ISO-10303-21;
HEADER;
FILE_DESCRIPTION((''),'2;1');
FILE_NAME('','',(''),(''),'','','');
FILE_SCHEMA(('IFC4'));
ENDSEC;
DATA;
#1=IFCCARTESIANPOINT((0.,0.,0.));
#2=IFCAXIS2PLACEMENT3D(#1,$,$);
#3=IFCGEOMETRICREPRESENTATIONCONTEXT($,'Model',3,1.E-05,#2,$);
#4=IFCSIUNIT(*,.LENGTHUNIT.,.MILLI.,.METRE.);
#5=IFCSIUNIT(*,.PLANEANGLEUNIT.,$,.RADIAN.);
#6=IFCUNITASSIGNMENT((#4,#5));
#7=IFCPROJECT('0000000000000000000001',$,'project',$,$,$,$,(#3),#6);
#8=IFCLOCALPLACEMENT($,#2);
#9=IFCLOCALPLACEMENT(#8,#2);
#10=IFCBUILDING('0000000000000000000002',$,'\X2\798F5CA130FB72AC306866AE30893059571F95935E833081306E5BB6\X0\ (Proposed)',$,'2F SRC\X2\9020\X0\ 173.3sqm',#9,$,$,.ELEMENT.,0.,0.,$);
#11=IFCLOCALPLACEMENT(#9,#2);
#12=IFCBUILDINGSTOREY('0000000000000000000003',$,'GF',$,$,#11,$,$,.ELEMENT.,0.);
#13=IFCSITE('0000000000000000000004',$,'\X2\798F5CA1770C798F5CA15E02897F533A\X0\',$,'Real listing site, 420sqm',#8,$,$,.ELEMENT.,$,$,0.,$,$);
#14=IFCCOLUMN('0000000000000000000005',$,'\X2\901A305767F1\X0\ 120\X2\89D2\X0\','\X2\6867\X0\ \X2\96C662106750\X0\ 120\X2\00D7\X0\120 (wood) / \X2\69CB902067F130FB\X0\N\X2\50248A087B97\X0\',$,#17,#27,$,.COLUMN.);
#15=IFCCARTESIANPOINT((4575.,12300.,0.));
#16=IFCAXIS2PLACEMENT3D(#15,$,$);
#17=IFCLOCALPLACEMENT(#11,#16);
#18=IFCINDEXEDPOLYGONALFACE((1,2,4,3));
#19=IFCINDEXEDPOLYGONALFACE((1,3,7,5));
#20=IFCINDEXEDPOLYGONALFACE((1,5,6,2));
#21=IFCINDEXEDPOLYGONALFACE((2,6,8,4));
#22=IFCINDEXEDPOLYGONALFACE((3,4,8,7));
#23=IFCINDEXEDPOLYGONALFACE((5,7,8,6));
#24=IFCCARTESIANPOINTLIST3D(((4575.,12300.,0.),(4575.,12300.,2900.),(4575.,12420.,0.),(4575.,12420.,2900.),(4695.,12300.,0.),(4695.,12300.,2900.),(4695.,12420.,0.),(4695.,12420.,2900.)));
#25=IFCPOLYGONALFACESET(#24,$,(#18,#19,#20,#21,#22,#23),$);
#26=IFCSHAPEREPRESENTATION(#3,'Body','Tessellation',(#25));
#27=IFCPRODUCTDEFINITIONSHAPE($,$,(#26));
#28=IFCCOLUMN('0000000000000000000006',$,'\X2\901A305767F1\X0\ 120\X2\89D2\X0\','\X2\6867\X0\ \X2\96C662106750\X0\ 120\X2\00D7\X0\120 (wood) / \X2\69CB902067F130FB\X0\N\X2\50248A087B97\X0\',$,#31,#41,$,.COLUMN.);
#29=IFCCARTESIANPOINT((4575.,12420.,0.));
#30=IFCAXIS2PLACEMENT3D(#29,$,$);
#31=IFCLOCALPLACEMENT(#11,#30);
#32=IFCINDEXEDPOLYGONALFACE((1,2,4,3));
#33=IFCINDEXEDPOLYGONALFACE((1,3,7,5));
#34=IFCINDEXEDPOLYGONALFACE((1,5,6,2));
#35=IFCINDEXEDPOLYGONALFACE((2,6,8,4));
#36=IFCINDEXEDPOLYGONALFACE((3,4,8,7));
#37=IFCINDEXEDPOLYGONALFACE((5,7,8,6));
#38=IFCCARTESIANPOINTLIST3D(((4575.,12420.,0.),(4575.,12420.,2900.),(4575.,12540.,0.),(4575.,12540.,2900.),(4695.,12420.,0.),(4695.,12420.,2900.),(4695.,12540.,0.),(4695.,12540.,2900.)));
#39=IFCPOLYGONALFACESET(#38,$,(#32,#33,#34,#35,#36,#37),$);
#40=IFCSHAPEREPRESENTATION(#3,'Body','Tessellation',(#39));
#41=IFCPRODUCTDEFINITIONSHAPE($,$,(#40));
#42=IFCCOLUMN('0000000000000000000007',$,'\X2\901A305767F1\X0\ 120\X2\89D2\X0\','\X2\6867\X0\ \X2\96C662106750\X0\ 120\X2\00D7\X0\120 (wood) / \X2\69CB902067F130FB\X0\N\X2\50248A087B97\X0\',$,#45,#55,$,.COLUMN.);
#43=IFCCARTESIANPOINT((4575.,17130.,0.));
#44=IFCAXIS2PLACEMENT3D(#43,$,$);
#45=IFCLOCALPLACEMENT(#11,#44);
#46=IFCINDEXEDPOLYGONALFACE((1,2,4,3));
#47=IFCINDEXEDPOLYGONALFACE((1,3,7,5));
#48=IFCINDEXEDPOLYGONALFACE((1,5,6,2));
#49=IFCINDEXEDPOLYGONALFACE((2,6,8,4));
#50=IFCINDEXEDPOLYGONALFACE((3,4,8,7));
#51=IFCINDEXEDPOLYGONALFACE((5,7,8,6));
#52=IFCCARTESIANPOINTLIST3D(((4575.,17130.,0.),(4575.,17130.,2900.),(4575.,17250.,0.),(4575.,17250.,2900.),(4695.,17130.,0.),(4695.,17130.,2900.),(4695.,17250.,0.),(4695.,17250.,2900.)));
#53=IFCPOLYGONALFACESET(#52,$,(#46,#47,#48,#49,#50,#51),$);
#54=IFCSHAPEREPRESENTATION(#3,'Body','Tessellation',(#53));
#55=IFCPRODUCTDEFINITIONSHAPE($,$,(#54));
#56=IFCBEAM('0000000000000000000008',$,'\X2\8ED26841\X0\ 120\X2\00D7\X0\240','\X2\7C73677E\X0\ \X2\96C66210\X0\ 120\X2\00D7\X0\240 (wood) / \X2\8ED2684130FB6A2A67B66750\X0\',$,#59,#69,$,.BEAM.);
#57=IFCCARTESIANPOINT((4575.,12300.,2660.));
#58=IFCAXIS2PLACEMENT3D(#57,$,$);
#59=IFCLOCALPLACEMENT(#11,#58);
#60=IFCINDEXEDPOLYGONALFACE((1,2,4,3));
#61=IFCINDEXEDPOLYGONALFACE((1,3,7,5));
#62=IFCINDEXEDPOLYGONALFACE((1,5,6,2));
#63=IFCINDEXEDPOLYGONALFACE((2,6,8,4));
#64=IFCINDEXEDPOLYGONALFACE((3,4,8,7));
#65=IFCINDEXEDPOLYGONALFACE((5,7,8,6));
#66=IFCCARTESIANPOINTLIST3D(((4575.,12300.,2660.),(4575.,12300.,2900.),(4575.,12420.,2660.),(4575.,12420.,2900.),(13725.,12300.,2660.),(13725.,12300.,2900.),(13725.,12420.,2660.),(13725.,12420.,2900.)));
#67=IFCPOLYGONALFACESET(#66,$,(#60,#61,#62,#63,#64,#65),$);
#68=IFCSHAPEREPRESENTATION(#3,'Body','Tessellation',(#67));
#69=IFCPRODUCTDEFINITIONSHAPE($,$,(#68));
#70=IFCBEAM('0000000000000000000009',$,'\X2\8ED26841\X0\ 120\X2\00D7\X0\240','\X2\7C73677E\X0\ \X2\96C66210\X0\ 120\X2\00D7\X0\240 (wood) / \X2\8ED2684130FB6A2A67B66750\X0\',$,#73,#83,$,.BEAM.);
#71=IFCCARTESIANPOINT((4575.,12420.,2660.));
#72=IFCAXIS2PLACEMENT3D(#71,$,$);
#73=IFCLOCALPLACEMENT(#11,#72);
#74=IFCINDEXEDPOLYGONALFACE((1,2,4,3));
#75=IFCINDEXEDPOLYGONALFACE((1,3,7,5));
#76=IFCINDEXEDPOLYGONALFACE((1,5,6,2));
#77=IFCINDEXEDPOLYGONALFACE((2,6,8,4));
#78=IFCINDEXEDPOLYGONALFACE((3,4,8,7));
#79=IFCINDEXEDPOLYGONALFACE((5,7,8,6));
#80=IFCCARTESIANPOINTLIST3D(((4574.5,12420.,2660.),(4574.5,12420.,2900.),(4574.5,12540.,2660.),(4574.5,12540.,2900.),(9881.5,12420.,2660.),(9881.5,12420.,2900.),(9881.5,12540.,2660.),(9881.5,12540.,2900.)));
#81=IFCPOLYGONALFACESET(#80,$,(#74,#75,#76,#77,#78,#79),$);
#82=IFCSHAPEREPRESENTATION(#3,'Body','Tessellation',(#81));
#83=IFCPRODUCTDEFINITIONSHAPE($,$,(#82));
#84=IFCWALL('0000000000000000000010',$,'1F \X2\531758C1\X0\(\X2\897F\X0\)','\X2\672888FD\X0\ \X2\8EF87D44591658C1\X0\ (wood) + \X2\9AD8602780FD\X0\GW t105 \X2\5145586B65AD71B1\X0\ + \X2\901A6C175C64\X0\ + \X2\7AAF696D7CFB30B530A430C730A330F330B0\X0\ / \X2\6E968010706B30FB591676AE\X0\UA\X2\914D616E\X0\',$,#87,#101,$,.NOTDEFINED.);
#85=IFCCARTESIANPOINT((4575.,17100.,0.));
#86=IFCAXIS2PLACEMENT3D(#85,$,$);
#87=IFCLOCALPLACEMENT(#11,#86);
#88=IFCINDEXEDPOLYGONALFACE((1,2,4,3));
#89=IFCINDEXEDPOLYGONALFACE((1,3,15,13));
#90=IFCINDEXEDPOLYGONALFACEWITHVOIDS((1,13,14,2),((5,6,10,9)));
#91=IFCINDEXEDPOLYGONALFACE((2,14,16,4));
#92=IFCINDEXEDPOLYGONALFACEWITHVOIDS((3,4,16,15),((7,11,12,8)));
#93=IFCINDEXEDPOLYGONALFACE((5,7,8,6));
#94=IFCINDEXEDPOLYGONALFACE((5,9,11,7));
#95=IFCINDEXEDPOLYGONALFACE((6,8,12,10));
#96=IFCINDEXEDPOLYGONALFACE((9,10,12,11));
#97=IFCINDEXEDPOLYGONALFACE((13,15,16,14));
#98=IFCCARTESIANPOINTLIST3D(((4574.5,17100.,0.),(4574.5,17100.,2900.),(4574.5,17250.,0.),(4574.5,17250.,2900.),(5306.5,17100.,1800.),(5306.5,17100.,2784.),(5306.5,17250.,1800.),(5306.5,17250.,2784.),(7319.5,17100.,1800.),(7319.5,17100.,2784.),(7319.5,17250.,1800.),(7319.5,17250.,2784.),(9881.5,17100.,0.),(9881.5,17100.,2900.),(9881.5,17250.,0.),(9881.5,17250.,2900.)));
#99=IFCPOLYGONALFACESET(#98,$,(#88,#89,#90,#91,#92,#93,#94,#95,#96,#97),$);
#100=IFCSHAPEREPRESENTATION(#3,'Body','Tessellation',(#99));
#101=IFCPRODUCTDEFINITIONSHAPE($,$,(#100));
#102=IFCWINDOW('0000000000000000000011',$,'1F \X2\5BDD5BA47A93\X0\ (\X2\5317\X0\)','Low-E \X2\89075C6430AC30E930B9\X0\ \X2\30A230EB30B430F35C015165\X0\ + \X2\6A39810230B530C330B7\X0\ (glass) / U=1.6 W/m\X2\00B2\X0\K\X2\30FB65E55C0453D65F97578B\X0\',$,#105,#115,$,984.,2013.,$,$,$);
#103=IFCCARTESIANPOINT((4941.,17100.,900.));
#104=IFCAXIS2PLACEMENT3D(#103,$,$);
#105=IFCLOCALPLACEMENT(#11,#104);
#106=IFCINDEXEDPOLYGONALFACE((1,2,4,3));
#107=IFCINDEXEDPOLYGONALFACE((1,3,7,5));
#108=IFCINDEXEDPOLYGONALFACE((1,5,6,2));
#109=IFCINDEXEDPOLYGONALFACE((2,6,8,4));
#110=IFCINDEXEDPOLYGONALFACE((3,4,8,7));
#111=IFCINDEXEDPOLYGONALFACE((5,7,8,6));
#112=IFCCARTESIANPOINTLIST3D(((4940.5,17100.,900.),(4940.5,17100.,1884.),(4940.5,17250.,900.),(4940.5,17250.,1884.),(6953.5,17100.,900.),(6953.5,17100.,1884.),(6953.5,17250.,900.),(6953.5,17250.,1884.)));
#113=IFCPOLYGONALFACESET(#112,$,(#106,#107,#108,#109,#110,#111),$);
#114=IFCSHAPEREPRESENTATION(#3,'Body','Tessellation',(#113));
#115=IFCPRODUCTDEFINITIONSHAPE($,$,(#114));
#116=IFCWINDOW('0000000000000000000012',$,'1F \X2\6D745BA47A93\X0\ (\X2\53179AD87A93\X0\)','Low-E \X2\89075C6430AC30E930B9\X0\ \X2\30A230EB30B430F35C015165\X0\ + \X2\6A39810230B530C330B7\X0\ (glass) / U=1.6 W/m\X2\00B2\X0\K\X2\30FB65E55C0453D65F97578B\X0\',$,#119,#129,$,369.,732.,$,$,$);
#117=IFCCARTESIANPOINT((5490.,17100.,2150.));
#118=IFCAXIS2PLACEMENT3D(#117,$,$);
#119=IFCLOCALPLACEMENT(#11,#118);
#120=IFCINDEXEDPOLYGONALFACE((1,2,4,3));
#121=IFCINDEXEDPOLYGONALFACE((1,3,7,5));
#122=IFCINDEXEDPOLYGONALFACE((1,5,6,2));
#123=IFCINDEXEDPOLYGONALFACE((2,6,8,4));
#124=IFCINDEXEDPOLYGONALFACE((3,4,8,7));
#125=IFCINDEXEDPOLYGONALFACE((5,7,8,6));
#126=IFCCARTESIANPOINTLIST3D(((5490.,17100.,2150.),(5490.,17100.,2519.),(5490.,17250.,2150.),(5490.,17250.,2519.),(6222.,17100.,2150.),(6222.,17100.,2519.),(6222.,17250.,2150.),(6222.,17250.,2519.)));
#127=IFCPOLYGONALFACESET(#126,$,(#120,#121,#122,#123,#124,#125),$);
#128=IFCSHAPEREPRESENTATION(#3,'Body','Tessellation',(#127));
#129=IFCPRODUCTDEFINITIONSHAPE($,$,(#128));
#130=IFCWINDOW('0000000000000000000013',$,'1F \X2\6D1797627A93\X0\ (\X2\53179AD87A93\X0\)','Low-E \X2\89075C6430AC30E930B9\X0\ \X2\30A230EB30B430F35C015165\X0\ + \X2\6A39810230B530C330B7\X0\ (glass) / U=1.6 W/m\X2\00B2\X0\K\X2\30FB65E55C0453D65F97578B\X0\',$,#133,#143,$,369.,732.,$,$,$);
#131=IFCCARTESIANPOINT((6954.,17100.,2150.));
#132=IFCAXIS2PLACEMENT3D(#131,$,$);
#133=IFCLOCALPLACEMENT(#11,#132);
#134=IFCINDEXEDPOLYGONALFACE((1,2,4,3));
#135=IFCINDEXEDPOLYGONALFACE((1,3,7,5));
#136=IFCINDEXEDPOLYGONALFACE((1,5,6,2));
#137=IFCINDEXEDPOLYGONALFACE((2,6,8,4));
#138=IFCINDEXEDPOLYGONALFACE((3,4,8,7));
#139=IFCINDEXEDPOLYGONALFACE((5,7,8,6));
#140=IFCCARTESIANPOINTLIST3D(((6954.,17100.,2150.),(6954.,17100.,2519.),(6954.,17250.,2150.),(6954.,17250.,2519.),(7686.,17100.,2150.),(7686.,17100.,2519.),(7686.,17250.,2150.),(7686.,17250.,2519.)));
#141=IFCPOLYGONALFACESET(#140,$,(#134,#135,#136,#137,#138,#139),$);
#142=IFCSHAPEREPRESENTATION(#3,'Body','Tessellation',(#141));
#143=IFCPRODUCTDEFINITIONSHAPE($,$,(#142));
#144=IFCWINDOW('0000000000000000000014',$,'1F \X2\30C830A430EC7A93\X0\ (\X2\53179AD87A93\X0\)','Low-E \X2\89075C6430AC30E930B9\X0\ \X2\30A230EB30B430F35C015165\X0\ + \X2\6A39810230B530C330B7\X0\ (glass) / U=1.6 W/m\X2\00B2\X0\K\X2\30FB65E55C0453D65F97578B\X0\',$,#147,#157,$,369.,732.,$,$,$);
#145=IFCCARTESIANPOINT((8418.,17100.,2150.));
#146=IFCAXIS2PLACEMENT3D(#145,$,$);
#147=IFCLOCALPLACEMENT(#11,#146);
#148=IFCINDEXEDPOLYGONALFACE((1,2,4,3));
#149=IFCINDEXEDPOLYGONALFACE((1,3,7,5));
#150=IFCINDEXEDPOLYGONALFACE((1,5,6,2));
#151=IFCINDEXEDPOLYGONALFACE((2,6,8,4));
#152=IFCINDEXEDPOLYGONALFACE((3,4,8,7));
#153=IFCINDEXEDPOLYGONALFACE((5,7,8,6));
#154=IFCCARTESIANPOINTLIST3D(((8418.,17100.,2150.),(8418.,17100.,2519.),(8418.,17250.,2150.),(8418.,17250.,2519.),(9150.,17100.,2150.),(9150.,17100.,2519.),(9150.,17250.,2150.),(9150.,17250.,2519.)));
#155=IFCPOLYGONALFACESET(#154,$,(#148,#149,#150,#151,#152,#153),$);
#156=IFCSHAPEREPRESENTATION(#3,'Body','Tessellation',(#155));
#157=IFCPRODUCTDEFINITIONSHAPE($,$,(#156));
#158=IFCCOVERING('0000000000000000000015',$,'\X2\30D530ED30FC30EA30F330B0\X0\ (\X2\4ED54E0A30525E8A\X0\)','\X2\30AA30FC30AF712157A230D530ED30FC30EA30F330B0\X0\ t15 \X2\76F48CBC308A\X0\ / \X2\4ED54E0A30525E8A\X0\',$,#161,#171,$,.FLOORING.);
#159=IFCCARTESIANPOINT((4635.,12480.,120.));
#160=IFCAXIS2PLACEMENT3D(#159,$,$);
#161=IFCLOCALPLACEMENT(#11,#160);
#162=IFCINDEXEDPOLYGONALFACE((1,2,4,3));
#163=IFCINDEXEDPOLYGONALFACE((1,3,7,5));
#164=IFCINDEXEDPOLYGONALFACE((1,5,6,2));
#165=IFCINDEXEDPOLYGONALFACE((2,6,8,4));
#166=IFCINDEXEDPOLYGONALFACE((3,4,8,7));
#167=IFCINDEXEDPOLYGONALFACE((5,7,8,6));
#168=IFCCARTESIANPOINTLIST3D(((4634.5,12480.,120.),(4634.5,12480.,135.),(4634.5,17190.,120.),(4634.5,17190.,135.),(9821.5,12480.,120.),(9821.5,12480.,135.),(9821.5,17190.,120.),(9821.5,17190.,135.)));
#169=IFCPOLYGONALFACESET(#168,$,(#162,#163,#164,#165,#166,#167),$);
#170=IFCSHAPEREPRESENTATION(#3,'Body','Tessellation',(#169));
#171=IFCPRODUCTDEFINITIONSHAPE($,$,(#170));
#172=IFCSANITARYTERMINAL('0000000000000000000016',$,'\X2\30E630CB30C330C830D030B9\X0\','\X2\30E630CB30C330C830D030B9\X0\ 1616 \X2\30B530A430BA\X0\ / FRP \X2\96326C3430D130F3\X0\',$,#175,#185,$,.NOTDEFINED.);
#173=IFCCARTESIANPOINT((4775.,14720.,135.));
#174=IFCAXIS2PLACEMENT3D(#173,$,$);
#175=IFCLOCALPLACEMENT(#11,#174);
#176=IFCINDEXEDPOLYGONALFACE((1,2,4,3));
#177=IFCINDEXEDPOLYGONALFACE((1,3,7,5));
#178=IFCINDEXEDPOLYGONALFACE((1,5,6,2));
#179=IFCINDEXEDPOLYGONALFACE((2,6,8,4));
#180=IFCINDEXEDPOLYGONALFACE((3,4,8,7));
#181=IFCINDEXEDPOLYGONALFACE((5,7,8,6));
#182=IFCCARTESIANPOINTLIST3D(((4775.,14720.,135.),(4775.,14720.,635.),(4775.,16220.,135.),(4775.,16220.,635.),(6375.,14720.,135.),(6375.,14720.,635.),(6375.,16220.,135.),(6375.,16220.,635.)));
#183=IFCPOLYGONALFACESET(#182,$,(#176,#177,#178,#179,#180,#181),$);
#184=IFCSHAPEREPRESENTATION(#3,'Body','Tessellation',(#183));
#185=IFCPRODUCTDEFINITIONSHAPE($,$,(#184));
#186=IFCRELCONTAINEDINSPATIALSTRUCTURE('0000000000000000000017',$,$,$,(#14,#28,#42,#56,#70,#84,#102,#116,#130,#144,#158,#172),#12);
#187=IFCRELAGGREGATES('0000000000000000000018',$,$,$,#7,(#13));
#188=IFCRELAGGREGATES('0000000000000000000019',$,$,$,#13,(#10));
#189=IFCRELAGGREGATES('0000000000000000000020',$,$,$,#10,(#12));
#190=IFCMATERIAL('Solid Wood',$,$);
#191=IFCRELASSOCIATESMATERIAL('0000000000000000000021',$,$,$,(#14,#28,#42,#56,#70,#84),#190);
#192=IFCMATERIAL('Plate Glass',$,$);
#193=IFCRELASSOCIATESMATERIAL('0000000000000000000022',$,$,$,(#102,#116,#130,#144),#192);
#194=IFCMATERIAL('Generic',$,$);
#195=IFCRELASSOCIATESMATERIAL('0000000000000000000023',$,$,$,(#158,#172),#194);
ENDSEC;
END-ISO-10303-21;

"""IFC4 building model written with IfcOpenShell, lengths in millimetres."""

from ifc_helpers import new_model, si_unit, frame, frame_2d, origin, place, context, project, spatial, rectangle, extrude, material, element, fill, save


model = new_model("IFC4")

# Units and contexts
model_context = context("Model", 3, precision=1e-05, world=origin())
ifc_project = project(units=[si_unit("LENGTHUNIT", "METRE", prefix="MILLI"), si_unit("PLANEANGLEUNIT", "RADIAN")], contexts=[model_context])

# Site, building, storey
site_placement = place(None, origin())
site = spatial("IfcSite", under=ifc_project, at=site_placement, Name="福岡県福岡市西区", ObjectType="Real listing site, 420sqm", CompositionType="ELEMENT", RefElevation=0.0)
building_placement = place(site_placement, origin())
building = spatial("IfcBuilding", under=site, at=building_placement, Name="福岡・犬と暮らす土間広めの家 (Proposed)", ObjectType="2F SRC造 173.3sqm", CompositionType="ELEMENT", ElevationOfRefHeight=0.0, ElevationOfTerrain=0.0)
storey_placement = place(building_placement, origin())
storey = spatial("IfcBuildingStorey", under=building, at=storey_placement, Name="GF", CompositionType="ELEMENT", Elevation=0.0)

# Columns
ifc_material_1 = material(Name="Solid Wood")
column_1_placement = place(storey_placement, frame((4575.0, 12300.0, 0.0)))
element("IfcColumn", 1, at=column_1_placement, inside=storey, material=ifc_material_1, Name="通し柱 120角", Description="桧 集成材 120×120 (wood) / 構造柱・N値計算", PredefinedType="COLUMN", context=model_context, shape_type="SweptSolid", body=[
    extrude(rectangle(XDim=120.0, YDim=120.0, at=frame_2d((60.0, 60.0))), frame((4575.0, 12300.0, 0.0)), (0.0, 0.0, 1.0), 2900.0),
])
column_2_placement = place(storey_placement, frame((4575.0, 12420.0, 0.0)))
element("IfcColumn", 2, at=column_2_placement, inside=storey, material=ifc_material_1, Name="通し柱 120角", Description="桧 集成材 120×120 (wood) / 構造柱・N値計算", PredefinedType="COLUMN", context=model_context, shape_type="SweptSolid", body=[
    extrude(rectangle(XDim=120.0, YDim=120.0, at=frame_2d((60.0, 60.0))), frame((4575.0, 12420.0, 0.0)), (0.0, 0.0, 1.0), 2900.0),
])
column_3_placement = place(storey_placement, frame((4575.0, 17130.0, 0.0)))
element("IfcColumn", 3, at=column_3_placement, inside=storey, material=ifc_material_1, Name="通し柱 120角", Description="桧 集成材 120×120 (wood) / 構造柱・N値計算", PredefinedType="COLUMN", context=model_context, shape_type="SweptSolid", body=[
    extrude(rectangle(XDim=120.0, YDim=120.0, at=frame_2d((60.0, 60.0))), frame((4575.0, 17130.0, 0.0)), (0.0, 0.0, 1.0), 2900.0),
])

# Beams
beam_1_placement = place(storey_placement, frame((4575.0, 12300.0, 2660.0)))
element("IfcBeam", 4, at=beam_1_placement, inside=storey, material=ifc_material_1, Name="軒桁 120×240", Description="米松 集成 120×240 (wood) / 軒桁・横架材", PredefinedType="BEAM", context=model_context, shape_type="SweptSolid", body=[
    extrude(rectangle(XDim=9150.0, YDim=120.0, at=frame_2d((4575.0, 60.0))), frame((4575.0, 12300.0, 2660.0)), (0.0, 0.0, 1.0), 240.0),
])
beam_2_placement = place(storey_placement, frame((4575.0, 12420.0, 2660.0)))
element("IfcBeam", 5, at=beam_2_placement, inside=storey, material=ifc_material_1, Name="軒桁 120×240", Description="米松 集成 120×240 (wood) / 軒桁・横架材", PredefinedType="BEAM", context=model_context, shape_type="SweptSolid", body=[
    extrude(rectangle(XDim=5307.0, YDim=120.0, at=frame_2d((2653.0, 60.0))), frame((4575.0, 12420.0, 2660.0)), (0.0, 0.0, 1.0), 240.0),
])

# Wall, openings, windows
wall_1_placement = place(storey_placement, frame((4575.0, 17100.0, 0.0)))
wall_1 = element("IfcWall", 6, at=wall_1_placement, inside=storey, material=ifc_material_1, Name="1F 北壁(西)", Description="木製 軸組外壁 (wood) + 高性能GW t105 充填断熱 + 通気層 + 窯業系サイディング / 準耐火・外皮UA配慮", PredefinedType="NOTDEFINED", context=model_context, shape_type="SweptSolid", body=[
    extrude(rectangle(XDim=5307.0, YDim=150.0, at=frame_2d((2653.0, 75.0))), frame((4575.0, 17100.0, 0.0)), (0.0, 0.0, 1.0), 2900.0),
])
opening_1_placement = place(storey_placement, frame((4941.0, 17100.0, 900.0)))
opening_1 = element("IfcOpeningElement", 7, at=opening_1_placement, cuts=wall_1, PredefinedType="NOTDEFINED", context=model_context, shape_type="SweptSolid", body=[
    extrude(rectangle(XDim=2013.0, YDim=150.0, at=frame_2d((1006.0, 75.0))), frame((4941.0, 17100.0, 900.0)), (0.0, 0.0, 1.0), 984.0),
])
opening_2_placement = place(storey_placement, frame((5490.0, 17100.0, 2150.0)))
opening_2 = element("IfcOpeningElement", 8, at=opening_2_placement, cuts=wall_1, PredefinedType="NOTDEFINED", context=model_context, shape_type="SweptSolid", body=[
    extrude(rectangle(XDim=732.0, YDim=150.0, at=frame_2d((366.0, 75.0))), frame((5490.0, 17100.0, 2150.0)), (0.0, 0.0, 1.0), 369.0),
])
opening_3_placement = place(storey_placement, frame((6954.0, 17100.0, 2150.0)))
opening_3 = element("IfcOpeningElement", 9, at=opening_3_placement, cuts=wall_1, PredefinedType="NOTDEFINED", context=model_context, shape_type="SweptSolid", body=[
    extrude(rectangle(XDim=732.0, YDim=150.0, at=frame_2d((366.0, 75.0))), frame((6954.0, 17100.0, 2150.0)), (0.0, 0.0, 1.0), 369.0),
])
opening_4_placement = place(storey_placement, frame((8418.0, 17100.0, 2150.0)))
opening_4 = element("IfcOpeningElement", 10, at=opening_4_placement, cuts=wall_1, PredefinedType="NOTDEFINED", context=model_context, shape_type="SweptSolid", body=[
    extrude(rectangle(XDim=732.0, YDim=150.0, at=frame_2d((366.0, 75.0))), frame((8418.0, 17100.0, 2150.0)), (0.0, 0.0, 1.0), 369.0),
])
ifc_material_2 = material(Name="Plate Glass")
window_1_placement = place(storey_placement, frame((4941.0, 17100.0, 900.0)))
window_1 = element("IfcWindow", 11, at=window_1_placement, inside=storey, material=ifc_material_2, Name="1F 寝室窓 (北)", Description="Low-E 複層ガラス アルゴン封入 + 樹脂サッシ (glass) / U=1.6 W/m²K・日射取得型", OverallHeight=984.0, OverallWidth=2013.0, context=model_context, shape_type="SweptSolid", body=[
    extrude(rectangle(XDim=2013.0, YDim=150.0, at=frame_2d((1006.0, 75.0))), frame((4941.0, 17100.0, 900.0)), (0.0, 0.0, 1.0), 984.0),
])
fill(opening_1, window_1)
window_2_placement = place(storey_placement, frame((5490.0, 17100.0, 2150.0)))
window_2 = element("IfcWindow", 12, at=window_2_placement, inside=storey, material=ifc_material_2, Name="1F 浴室窓 (北高窓)", Description="Low-E 複層ガラス アルゴン封入 + 樹脂サッシ (glass) / U=1.6 W/m²K・日射取得型", OverallHeight=369.0, OverallWidth=732.0, context=model_context, shape_type="SweptSolid", body=[
    extrude(rectangle(XDim=732.0, YDim=150.0, at=frame_2d((366.0, 75.0))), frame((5490.0, 17100.0, 2150.0)), (0.0, 0.0, 1.0), 369.0),
])
fill(opening_2, window_2)
window_3_placement = place(storey_placement, frame((6954.0, 17100.0, 2150.0)))
window_3 = element("IfcWindow", 13, at=window_3_placement, inside=storey, material=ifc_material_2, Name="1F 洗面窓 (北高窓)", Description="Low-E 複層ガラス アルゴン封入 + 樹脂サッシ (glass) / U=1.6 W/m²K・日射取得型", OverallHeight=369.0, OverallWidth=732.0, context=model_context, shape_type="SweptSolid", body=[
    extrude(rectangle(XDim=732.0, YDim=150.0, at=frame_2d((366.0, 75.0))), frame((6954.0, 17100.0, 2150.0)), (0.0, 0.0, 1.0), 369.0),
])
fill(opening_3, window_3)
window_4_placement = place(storey_placement, frame((8418.0, 17100.0, 2150.0)))
window_4 = element("IfcWindow", 14, at=window_4_placement, inside=storey, material=ifc_material_2, Name="1F トイレ窓 (北高窓)", Description="Low-E 複層ガラス アルゴン封入 + 樹脂サッシ (glass) / U=1.6 W/m²K・日射取得型", OverallHeight=369.0, OverallWidth=732.0, context=model_context, shape_type="SweptSolid", body=[
    extrude(rectangle(XDim=732.0, YDim=150.0, at=frame_2d((366.0, 75.0))), frame((8418.0, 17100.0, 2150.0)), (0.0, 0.0, 1.0), 369.0),
])
fill(opening_4, window_4)

# Covering
ifc_material_3 = material(Name="Generic")
covering_placement = place(storey_placement, frame((4635.0, 12480.0, 120.0)))
element("IfcCovering", 15, at=covering_placement, inside=storey, material=ifc_material_3, Name="フローリング (仕上げ床)", Description="オーク無垢フローリング t15 直貼り / 仕上げ床", PredefinedType="FLOORING", context=model_context, shape_type="SweptSolid", body=[
    extrude(rectangle(XDim=5187.0, YDim=4710.0, at=frame_2d((2593.0, 2355.0))), frame((4635.0, 12480.0, 120.0)), (0.0, 0.0, 1.0), 15.0),
])

# Sanitary terminal
sanitary_terminal_placement = place(storey_placement, frame((4775.0, 14720.0, 135.0)))
element("IfcSanitaryTerminal", 16, at=sanitary_terminal_placement, inside=storey, material=ifc_material_3, Name="ユニットバス", Description="ユニットバス 1616 サイズ / FRP 防水パン", PredefinedType="NOTDEFINED", context=model_context, shape_type="SweptSolid", body=[
    extrude(rectangle(XDim=1600.0, YDim=1500.0, at=frame_2d((800.0, 750.0))), frame((4775.0, 14720.0, 135.0)), (0.0, 0.0, 1.0), 500.0),
])

save(model, "model.ifc")
